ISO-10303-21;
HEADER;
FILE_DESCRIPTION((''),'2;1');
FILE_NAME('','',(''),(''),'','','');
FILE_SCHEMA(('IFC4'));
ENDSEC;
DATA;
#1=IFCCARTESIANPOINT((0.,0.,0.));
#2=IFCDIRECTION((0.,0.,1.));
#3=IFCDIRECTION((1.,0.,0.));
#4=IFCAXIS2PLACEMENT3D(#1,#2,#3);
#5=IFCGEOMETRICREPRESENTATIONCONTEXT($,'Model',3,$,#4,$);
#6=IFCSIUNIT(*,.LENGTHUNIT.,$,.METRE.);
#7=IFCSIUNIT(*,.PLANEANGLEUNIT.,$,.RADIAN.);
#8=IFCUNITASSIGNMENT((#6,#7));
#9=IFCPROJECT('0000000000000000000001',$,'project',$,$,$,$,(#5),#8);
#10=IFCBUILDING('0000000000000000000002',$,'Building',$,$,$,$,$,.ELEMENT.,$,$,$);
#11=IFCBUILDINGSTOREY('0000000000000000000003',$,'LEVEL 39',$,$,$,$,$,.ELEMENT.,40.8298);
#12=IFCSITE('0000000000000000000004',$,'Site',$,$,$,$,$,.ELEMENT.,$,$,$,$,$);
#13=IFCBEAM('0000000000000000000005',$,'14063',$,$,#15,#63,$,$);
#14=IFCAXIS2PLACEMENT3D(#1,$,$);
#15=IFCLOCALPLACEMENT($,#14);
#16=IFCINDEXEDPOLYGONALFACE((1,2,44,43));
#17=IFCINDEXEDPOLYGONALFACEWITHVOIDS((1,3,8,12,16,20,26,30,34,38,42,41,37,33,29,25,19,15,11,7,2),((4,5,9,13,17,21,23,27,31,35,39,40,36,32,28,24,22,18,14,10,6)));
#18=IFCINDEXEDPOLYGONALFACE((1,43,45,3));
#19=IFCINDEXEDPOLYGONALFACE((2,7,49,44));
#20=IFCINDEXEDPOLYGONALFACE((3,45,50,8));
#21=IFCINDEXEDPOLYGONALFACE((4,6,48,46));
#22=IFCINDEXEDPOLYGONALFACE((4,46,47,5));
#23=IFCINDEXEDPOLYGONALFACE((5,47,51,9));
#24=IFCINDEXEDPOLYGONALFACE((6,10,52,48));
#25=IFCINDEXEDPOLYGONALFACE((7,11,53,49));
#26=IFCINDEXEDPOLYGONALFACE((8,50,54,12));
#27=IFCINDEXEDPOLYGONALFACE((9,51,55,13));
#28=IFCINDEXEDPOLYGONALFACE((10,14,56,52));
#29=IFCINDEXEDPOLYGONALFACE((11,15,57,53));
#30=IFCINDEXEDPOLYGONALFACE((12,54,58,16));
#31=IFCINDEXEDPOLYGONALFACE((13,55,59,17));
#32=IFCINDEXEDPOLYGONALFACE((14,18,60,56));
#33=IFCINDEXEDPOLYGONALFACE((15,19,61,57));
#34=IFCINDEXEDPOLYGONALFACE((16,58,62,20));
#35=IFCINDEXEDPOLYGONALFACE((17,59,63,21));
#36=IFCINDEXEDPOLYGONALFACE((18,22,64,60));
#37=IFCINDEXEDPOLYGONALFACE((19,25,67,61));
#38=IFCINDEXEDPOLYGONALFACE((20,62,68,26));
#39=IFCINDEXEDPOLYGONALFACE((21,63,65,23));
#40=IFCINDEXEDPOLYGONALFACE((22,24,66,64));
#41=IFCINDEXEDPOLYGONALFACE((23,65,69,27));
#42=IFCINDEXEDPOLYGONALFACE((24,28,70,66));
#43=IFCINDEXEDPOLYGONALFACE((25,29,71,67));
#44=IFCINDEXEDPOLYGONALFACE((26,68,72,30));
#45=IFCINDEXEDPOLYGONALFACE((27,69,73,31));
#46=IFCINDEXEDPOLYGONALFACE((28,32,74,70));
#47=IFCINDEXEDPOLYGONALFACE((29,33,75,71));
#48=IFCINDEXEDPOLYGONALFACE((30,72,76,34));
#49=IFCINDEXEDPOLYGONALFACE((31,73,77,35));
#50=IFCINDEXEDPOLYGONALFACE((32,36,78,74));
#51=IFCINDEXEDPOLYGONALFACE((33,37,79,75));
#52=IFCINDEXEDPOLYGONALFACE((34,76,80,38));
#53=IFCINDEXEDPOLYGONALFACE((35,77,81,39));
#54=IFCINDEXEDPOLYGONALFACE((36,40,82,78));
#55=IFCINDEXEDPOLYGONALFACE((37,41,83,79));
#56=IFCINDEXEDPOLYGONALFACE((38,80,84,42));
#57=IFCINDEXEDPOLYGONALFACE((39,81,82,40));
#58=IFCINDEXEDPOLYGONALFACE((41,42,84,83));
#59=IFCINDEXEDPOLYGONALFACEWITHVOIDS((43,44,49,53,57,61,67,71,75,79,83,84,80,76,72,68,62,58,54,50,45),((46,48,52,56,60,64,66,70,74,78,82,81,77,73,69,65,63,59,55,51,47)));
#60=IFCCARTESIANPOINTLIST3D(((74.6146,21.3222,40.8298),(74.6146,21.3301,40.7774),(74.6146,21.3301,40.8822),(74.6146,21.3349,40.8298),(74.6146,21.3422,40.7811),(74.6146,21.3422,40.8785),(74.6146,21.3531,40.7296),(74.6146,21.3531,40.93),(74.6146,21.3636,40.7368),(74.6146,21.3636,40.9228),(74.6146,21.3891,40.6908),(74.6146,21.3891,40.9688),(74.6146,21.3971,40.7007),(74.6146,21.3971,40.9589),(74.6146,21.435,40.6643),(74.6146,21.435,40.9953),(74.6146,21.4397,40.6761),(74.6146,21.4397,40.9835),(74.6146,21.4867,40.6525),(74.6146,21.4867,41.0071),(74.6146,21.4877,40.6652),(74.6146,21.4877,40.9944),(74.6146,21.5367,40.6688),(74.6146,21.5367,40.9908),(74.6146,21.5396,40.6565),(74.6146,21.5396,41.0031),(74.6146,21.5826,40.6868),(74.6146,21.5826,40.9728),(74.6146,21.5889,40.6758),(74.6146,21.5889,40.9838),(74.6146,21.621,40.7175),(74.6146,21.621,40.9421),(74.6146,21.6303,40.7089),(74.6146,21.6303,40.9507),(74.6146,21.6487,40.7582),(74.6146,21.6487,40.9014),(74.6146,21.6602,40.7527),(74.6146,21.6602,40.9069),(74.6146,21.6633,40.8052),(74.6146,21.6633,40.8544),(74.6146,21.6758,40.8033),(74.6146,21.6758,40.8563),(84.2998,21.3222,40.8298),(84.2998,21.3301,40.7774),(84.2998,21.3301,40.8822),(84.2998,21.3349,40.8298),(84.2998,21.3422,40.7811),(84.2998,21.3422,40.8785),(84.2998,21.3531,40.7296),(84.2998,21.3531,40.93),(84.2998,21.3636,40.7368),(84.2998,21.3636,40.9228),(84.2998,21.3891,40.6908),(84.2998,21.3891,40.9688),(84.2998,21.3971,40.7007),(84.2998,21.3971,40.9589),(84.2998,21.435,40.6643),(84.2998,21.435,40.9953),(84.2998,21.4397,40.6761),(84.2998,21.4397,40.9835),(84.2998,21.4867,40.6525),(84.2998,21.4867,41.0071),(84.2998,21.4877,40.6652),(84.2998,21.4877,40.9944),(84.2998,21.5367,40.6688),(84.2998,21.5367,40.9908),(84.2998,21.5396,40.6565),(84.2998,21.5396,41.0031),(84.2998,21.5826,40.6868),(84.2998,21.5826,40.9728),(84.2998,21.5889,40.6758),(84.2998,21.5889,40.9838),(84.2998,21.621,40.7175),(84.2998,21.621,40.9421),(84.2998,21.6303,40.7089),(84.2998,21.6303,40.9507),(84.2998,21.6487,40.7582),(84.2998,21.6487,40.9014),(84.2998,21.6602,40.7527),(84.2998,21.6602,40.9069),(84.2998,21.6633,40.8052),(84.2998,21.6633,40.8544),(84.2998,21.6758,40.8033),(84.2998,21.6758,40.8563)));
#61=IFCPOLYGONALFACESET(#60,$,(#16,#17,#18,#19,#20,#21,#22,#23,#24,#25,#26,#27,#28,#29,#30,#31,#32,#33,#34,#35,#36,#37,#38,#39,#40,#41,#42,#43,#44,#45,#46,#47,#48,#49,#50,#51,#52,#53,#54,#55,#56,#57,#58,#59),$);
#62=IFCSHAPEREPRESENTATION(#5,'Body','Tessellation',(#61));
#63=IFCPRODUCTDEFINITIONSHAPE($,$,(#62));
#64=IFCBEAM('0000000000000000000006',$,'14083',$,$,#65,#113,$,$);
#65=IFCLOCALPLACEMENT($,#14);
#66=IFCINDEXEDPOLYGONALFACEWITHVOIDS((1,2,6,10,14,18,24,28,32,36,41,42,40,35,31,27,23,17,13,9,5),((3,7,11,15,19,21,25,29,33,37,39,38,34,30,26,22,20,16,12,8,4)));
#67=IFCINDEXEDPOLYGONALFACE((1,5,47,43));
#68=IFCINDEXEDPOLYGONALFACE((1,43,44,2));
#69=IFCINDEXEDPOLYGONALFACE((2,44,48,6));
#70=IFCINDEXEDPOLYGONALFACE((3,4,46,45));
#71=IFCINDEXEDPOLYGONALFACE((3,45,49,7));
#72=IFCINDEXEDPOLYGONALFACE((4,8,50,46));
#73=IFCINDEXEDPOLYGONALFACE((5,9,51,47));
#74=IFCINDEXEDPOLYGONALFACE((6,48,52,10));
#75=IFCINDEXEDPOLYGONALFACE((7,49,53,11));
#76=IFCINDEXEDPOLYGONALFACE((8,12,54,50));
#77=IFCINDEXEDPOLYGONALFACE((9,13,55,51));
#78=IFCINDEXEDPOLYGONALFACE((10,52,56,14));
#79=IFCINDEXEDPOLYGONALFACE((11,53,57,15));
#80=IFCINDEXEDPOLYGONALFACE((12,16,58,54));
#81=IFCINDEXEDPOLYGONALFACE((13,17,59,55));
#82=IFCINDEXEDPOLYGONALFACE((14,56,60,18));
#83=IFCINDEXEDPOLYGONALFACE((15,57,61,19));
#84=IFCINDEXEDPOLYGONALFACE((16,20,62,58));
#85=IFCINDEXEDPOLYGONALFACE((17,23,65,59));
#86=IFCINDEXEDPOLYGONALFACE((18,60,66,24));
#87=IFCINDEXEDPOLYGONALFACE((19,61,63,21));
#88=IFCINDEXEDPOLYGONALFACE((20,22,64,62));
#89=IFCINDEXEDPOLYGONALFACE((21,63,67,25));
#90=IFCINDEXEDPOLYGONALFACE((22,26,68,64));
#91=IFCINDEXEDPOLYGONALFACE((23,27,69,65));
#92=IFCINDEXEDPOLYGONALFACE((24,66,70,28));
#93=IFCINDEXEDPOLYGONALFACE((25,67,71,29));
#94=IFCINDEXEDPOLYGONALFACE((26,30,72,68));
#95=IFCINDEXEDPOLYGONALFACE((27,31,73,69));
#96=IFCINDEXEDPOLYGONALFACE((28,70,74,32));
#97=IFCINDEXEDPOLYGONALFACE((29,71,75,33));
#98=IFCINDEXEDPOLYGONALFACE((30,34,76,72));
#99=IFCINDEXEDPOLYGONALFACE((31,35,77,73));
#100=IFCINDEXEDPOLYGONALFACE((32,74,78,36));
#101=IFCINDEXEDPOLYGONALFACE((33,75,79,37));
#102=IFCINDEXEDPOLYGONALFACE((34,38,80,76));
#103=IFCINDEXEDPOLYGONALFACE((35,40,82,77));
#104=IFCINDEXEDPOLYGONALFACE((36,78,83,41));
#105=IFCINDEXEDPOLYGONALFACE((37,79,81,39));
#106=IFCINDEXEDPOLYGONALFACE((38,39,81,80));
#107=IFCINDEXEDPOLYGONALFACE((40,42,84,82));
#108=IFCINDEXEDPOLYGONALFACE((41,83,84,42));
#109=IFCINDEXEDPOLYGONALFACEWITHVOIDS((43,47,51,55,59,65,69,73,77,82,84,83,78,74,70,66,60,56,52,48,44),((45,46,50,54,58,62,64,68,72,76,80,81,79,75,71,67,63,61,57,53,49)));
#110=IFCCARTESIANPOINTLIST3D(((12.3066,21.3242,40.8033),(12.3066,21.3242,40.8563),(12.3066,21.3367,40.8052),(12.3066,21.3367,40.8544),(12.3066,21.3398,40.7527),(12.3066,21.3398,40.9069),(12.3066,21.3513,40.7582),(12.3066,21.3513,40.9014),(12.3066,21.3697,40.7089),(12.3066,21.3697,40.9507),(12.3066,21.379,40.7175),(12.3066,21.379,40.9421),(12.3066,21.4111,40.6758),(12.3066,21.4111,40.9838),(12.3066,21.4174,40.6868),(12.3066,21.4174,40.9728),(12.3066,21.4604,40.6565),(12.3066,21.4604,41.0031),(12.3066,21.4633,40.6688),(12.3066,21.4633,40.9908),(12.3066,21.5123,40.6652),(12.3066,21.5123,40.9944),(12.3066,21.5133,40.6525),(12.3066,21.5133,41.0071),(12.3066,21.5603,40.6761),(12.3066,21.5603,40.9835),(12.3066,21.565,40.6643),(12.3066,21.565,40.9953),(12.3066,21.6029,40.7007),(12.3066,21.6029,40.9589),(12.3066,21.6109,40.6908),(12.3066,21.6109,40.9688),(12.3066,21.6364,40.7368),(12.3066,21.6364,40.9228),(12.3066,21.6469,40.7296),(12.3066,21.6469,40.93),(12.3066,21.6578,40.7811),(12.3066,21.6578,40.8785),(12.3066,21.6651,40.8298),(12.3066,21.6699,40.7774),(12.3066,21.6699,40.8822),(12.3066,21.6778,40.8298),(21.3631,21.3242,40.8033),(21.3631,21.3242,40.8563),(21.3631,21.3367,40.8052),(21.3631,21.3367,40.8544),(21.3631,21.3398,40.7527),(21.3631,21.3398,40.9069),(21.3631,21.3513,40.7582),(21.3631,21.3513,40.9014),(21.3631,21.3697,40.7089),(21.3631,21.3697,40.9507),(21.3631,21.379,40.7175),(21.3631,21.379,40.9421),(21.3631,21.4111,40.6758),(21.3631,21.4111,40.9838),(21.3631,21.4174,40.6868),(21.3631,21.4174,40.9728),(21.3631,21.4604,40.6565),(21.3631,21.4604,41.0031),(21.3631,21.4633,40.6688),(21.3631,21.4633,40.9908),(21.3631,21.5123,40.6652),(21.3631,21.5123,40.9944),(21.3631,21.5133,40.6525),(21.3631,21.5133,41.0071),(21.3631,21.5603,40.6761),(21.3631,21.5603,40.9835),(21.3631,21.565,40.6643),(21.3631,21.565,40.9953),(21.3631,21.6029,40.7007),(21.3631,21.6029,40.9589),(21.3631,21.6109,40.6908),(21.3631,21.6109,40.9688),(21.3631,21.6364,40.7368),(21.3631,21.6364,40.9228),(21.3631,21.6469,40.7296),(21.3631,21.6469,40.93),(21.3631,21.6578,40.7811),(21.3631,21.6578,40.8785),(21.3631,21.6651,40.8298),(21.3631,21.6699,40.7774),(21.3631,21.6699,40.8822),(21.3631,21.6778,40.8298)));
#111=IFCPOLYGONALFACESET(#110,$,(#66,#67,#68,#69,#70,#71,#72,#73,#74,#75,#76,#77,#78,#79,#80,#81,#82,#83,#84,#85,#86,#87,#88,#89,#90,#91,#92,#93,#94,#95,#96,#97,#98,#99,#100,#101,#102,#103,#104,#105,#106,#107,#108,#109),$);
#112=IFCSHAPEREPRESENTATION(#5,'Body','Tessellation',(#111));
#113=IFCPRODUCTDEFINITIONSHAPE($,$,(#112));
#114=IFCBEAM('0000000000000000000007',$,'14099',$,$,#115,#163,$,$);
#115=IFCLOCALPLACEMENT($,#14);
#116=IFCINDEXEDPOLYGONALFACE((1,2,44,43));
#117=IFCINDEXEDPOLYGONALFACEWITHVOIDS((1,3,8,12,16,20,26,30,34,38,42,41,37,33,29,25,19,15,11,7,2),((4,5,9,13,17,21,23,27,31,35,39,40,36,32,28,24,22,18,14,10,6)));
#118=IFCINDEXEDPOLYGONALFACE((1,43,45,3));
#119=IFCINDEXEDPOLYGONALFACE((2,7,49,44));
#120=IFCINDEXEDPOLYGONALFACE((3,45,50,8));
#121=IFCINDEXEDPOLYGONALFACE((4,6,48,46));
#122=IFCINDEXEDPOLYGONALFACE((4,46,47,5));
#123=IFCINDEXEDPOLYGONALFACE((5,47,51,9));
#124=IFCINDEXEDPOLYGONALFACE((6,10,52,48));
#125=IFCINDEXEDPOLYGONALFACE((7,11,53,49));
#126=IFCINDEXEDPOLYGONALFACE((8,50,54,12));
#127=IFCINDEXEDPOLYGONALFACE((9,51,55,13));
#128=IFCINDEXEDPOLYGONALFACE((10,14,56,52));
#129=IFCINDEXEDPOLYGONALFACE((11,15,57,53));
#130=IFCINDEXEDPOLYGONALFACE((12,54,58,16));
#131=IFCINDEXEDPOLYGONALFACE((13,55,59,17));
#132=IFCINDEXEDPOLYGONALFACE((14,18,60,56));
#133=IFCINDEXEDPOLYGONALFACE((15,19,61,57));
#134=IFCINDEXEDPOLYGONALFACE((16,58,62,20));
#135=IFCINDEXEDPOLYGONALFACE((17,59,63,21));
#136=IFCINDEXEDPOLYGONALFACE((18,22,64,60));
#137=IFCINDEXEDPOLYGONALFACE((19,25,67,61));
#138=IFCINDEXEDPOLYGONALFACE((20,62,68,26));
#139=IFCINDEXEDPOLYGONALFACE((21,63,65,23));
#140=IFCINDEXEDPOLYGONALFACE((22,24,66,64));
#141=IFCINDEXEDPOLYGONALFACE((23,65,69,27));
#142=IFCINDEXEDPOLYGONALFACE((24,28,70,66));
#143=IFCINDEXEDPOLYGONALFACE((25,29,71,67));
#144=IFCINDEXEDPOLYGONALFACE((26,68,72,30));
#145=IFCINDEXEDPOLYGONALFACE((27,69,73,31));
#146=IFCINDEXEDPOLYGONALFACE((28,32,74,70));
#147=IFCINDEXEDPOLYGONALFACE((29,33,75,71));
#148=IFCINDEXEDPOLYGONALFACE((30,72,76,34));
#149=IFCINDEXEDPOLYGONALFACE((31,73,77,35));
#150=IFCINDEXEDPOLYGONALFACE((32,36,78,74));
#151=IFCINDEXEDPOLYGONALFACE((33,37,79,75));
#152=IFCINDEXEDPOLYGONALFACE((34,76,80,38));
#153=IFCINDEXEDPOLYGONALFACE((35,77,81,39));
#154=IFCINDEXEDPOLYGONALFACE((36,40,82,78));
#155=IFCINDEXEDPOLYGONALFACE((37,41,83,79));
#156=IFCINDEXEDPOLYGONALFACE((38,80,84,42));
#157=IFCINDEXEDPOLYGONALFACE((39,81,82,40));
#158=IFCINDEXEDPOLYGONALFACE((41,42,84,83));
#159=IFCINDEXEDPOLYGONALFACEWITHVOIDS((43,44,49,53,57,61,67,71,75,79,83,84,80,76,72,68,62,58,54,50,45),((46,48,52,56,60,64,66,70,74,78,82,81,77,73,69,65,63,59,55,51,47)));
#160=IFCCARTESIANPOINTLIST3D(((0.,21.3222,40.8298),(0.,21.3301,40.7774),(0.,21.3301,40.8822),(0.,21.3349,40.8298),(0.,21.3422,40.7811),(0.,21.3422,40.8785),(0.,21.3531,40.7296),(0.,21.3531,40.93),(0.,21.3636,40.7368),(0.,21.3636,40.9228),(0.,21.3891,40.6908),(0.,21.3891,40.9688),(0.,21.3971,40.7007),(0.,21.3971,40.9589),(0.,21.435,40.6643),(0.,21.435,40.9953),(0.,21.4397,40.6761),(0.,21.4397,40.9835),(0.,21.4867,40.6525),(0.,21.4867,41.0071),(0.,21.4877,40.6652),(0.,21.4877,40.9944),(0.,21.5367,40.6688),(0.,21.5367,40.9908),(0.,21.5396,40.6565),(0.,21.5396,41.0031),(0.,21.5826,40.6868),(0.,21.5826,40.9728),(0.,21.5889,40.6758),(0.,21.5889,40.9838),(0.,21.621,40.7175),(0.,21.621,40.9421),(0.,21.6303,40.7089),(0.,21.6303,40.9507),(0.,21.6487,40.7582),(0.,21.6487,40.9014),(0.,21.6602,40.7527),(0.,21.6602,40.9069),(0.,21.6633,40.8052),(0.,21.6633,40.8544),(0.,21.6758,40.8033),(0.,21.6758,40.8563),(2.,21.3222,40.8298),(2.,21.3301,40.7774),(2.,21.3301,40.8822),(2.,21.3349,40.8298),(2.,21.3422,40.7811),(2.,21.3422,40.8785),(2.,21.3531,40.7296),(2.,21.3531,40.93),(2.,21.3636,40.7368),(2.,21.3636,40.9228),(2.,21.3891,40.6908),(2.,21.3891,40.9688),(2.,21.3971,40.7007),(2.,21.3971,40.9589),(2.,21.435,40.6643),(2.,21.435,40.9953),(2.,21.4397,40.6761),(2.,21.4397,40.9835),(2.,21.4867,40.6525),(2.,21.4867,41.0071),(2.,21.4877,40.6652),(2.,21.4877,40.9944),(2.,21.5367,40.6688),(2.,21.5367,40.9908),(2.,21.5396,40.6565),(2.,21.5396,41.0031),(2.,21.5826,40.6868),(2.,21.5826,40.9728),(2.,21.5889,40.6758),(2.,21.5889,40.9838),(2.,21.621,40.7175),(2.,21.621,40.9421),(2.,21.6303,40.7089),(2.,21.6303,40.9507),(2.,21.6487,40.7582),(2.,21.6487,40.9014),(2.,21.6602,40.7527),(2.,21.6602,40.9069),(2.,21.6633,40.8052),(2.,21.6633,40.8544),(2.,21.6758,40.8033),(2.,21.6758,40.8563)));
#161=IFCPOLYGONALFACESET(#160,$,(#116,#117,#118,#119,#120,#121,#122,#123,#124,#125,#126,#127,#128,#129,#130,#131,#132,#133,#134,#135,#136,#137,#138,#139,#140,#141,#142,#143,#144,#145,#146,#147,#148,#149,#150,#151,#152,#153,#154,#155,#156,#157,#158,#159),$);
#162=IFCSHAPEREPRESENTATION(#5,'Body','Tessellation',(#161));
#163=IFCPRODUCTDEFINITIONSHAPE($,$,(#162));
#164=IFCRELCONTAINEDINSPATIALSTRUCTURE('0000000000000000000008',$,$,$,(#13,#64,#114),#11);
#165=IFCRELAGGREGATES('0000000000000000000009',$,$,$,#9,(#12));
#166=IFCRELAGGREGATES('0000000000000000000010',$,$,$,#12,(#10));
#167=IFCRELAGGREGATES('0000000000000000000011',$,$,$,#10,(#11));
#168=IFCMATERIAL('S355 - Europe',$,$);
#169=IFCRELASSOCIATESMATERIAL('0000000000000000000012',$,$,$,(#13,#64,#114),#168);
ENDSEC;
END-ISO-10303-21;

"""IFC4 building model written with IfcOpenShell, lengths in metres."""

from ifc_helpers import new_model, si_unit, frame, origin_with_axes, origin_2d_with_axis, place, context, project, spatial, hollow_circle, extrude, material, material_profile, profile_set, profile_usage, element, save


model = new_model("IFC4")

# Units and contexts
model_context = context("Model", 3, world=origin_with_axes())
ifc_project = project(units=[si_unit("LENGTHUNIT", "METRE"), si_unit("PLANEANGLEUNIT", "RADIAN")], contexts=[model_context])

# Site, building, storey
site = spatial("IfcSite", under=ifc_project, Name="Site", CompositionType="ELEMENT")
building = spatial("IfcBuilding", under=site, Name="Building", CompositionType="ELEMENT")
storey = spatial("IfcBuildingStorey", under=building, Name="LEVEL 39", CompositionType="ELEMENT", Elevation=40.8298)

# Beams
ifc_material = material(Name="S355 - Europe")
ifc_material_profile_1 = material_profile(ifc_material, hollow_circle(Radius=0.1778, WallThickness=0.0127, at=origin_2d_with_axis()))
ifc_profile_set_1 = profile_set([ifc_material_profile_1])
ifc_profile_usage_1 = profile_usage(ifc_profile_set_1, cardinal=10)
beam_1_placement = place(None, frame((84.2998, 21.5, 40.8298), z_axis=(-1.0, 0.0, 0.0), x_axis=(0.0, -1.0, 0.0)))
element("IfcBeam", 1, at=beam_1_placement, inside=storey, material=ifc_profile_usage_1, Name="14063", context=model_context, shape_type="SweptSolid", body=[
    extrude(hollow_circle(Radius=0.1778, WallThickness=0.0127, at=origin_2d_with_axis()), origin_with_axes(), (0.0, 0.0, 1.0), 9.6852),
])
ifc_material_profile_2 = material_profile(ifc_material, hollow_circle(Radius=0.1778, WallThickness=0.0127, at=origin_2d_with_axis()))
ifc_profile_set_2 = profile_set([ifc_material_profile_2])
ifc_profile_usage_2 = profile_usage(ifc_profile_set_2, cardinal=10)
beam_2_placement = place(None, frame((12.3066, 21.5, 40.8298), z_axis=(1.0, 0.0, 0.0), x_axis=(0.0, 1.0, 0.0)))
element("IfcBeam", 2, at=beam_2_placement, inside=storey, material=ifc_profile_usage_2, Name="14083", context=model_context, shape_type="SweptSolid", body=[
    extrude(hollow_circle(Radius=0.1778, WallThickness=0.0127, at=origin_2d_with_axis()), origin_with_axes(), (0.0, 0.0, 1.0), 9.0565),
])
ifc_material_profile_3 = material_profile(ifc_material, hollow_circle(Radius=0.1778, WallThickness=0.0127, at=origin_2d_with_axis()))
ifc_profile_set_3 = profile_set([ifc_material_profile_3])
ifc_profile_usage_3 = profile_usage(ifc_profile_set_3, cardinal=10)
beam_3_placement = place(None, frame((2.0, 21.5, 40.8298), z_axis=(-1.0, 0.0, 0.0), x_axis=(0.0, -1.0, 0.0)))
element("IfcBeam", 3, at=beam_3_placement, inside=storey, material=ifc_profile_usage_3, Name="14099", context=model_context, shape_type="SweptSolid", body=[
    extrude(hollow_circle(Radius=0.1778, WallThickness=0.0127, at=origin_2d_with_axis()), origin_with_axes(), (0.0, 0.0, 1.0), 2.0),
])

save(model, "model.ifc")
